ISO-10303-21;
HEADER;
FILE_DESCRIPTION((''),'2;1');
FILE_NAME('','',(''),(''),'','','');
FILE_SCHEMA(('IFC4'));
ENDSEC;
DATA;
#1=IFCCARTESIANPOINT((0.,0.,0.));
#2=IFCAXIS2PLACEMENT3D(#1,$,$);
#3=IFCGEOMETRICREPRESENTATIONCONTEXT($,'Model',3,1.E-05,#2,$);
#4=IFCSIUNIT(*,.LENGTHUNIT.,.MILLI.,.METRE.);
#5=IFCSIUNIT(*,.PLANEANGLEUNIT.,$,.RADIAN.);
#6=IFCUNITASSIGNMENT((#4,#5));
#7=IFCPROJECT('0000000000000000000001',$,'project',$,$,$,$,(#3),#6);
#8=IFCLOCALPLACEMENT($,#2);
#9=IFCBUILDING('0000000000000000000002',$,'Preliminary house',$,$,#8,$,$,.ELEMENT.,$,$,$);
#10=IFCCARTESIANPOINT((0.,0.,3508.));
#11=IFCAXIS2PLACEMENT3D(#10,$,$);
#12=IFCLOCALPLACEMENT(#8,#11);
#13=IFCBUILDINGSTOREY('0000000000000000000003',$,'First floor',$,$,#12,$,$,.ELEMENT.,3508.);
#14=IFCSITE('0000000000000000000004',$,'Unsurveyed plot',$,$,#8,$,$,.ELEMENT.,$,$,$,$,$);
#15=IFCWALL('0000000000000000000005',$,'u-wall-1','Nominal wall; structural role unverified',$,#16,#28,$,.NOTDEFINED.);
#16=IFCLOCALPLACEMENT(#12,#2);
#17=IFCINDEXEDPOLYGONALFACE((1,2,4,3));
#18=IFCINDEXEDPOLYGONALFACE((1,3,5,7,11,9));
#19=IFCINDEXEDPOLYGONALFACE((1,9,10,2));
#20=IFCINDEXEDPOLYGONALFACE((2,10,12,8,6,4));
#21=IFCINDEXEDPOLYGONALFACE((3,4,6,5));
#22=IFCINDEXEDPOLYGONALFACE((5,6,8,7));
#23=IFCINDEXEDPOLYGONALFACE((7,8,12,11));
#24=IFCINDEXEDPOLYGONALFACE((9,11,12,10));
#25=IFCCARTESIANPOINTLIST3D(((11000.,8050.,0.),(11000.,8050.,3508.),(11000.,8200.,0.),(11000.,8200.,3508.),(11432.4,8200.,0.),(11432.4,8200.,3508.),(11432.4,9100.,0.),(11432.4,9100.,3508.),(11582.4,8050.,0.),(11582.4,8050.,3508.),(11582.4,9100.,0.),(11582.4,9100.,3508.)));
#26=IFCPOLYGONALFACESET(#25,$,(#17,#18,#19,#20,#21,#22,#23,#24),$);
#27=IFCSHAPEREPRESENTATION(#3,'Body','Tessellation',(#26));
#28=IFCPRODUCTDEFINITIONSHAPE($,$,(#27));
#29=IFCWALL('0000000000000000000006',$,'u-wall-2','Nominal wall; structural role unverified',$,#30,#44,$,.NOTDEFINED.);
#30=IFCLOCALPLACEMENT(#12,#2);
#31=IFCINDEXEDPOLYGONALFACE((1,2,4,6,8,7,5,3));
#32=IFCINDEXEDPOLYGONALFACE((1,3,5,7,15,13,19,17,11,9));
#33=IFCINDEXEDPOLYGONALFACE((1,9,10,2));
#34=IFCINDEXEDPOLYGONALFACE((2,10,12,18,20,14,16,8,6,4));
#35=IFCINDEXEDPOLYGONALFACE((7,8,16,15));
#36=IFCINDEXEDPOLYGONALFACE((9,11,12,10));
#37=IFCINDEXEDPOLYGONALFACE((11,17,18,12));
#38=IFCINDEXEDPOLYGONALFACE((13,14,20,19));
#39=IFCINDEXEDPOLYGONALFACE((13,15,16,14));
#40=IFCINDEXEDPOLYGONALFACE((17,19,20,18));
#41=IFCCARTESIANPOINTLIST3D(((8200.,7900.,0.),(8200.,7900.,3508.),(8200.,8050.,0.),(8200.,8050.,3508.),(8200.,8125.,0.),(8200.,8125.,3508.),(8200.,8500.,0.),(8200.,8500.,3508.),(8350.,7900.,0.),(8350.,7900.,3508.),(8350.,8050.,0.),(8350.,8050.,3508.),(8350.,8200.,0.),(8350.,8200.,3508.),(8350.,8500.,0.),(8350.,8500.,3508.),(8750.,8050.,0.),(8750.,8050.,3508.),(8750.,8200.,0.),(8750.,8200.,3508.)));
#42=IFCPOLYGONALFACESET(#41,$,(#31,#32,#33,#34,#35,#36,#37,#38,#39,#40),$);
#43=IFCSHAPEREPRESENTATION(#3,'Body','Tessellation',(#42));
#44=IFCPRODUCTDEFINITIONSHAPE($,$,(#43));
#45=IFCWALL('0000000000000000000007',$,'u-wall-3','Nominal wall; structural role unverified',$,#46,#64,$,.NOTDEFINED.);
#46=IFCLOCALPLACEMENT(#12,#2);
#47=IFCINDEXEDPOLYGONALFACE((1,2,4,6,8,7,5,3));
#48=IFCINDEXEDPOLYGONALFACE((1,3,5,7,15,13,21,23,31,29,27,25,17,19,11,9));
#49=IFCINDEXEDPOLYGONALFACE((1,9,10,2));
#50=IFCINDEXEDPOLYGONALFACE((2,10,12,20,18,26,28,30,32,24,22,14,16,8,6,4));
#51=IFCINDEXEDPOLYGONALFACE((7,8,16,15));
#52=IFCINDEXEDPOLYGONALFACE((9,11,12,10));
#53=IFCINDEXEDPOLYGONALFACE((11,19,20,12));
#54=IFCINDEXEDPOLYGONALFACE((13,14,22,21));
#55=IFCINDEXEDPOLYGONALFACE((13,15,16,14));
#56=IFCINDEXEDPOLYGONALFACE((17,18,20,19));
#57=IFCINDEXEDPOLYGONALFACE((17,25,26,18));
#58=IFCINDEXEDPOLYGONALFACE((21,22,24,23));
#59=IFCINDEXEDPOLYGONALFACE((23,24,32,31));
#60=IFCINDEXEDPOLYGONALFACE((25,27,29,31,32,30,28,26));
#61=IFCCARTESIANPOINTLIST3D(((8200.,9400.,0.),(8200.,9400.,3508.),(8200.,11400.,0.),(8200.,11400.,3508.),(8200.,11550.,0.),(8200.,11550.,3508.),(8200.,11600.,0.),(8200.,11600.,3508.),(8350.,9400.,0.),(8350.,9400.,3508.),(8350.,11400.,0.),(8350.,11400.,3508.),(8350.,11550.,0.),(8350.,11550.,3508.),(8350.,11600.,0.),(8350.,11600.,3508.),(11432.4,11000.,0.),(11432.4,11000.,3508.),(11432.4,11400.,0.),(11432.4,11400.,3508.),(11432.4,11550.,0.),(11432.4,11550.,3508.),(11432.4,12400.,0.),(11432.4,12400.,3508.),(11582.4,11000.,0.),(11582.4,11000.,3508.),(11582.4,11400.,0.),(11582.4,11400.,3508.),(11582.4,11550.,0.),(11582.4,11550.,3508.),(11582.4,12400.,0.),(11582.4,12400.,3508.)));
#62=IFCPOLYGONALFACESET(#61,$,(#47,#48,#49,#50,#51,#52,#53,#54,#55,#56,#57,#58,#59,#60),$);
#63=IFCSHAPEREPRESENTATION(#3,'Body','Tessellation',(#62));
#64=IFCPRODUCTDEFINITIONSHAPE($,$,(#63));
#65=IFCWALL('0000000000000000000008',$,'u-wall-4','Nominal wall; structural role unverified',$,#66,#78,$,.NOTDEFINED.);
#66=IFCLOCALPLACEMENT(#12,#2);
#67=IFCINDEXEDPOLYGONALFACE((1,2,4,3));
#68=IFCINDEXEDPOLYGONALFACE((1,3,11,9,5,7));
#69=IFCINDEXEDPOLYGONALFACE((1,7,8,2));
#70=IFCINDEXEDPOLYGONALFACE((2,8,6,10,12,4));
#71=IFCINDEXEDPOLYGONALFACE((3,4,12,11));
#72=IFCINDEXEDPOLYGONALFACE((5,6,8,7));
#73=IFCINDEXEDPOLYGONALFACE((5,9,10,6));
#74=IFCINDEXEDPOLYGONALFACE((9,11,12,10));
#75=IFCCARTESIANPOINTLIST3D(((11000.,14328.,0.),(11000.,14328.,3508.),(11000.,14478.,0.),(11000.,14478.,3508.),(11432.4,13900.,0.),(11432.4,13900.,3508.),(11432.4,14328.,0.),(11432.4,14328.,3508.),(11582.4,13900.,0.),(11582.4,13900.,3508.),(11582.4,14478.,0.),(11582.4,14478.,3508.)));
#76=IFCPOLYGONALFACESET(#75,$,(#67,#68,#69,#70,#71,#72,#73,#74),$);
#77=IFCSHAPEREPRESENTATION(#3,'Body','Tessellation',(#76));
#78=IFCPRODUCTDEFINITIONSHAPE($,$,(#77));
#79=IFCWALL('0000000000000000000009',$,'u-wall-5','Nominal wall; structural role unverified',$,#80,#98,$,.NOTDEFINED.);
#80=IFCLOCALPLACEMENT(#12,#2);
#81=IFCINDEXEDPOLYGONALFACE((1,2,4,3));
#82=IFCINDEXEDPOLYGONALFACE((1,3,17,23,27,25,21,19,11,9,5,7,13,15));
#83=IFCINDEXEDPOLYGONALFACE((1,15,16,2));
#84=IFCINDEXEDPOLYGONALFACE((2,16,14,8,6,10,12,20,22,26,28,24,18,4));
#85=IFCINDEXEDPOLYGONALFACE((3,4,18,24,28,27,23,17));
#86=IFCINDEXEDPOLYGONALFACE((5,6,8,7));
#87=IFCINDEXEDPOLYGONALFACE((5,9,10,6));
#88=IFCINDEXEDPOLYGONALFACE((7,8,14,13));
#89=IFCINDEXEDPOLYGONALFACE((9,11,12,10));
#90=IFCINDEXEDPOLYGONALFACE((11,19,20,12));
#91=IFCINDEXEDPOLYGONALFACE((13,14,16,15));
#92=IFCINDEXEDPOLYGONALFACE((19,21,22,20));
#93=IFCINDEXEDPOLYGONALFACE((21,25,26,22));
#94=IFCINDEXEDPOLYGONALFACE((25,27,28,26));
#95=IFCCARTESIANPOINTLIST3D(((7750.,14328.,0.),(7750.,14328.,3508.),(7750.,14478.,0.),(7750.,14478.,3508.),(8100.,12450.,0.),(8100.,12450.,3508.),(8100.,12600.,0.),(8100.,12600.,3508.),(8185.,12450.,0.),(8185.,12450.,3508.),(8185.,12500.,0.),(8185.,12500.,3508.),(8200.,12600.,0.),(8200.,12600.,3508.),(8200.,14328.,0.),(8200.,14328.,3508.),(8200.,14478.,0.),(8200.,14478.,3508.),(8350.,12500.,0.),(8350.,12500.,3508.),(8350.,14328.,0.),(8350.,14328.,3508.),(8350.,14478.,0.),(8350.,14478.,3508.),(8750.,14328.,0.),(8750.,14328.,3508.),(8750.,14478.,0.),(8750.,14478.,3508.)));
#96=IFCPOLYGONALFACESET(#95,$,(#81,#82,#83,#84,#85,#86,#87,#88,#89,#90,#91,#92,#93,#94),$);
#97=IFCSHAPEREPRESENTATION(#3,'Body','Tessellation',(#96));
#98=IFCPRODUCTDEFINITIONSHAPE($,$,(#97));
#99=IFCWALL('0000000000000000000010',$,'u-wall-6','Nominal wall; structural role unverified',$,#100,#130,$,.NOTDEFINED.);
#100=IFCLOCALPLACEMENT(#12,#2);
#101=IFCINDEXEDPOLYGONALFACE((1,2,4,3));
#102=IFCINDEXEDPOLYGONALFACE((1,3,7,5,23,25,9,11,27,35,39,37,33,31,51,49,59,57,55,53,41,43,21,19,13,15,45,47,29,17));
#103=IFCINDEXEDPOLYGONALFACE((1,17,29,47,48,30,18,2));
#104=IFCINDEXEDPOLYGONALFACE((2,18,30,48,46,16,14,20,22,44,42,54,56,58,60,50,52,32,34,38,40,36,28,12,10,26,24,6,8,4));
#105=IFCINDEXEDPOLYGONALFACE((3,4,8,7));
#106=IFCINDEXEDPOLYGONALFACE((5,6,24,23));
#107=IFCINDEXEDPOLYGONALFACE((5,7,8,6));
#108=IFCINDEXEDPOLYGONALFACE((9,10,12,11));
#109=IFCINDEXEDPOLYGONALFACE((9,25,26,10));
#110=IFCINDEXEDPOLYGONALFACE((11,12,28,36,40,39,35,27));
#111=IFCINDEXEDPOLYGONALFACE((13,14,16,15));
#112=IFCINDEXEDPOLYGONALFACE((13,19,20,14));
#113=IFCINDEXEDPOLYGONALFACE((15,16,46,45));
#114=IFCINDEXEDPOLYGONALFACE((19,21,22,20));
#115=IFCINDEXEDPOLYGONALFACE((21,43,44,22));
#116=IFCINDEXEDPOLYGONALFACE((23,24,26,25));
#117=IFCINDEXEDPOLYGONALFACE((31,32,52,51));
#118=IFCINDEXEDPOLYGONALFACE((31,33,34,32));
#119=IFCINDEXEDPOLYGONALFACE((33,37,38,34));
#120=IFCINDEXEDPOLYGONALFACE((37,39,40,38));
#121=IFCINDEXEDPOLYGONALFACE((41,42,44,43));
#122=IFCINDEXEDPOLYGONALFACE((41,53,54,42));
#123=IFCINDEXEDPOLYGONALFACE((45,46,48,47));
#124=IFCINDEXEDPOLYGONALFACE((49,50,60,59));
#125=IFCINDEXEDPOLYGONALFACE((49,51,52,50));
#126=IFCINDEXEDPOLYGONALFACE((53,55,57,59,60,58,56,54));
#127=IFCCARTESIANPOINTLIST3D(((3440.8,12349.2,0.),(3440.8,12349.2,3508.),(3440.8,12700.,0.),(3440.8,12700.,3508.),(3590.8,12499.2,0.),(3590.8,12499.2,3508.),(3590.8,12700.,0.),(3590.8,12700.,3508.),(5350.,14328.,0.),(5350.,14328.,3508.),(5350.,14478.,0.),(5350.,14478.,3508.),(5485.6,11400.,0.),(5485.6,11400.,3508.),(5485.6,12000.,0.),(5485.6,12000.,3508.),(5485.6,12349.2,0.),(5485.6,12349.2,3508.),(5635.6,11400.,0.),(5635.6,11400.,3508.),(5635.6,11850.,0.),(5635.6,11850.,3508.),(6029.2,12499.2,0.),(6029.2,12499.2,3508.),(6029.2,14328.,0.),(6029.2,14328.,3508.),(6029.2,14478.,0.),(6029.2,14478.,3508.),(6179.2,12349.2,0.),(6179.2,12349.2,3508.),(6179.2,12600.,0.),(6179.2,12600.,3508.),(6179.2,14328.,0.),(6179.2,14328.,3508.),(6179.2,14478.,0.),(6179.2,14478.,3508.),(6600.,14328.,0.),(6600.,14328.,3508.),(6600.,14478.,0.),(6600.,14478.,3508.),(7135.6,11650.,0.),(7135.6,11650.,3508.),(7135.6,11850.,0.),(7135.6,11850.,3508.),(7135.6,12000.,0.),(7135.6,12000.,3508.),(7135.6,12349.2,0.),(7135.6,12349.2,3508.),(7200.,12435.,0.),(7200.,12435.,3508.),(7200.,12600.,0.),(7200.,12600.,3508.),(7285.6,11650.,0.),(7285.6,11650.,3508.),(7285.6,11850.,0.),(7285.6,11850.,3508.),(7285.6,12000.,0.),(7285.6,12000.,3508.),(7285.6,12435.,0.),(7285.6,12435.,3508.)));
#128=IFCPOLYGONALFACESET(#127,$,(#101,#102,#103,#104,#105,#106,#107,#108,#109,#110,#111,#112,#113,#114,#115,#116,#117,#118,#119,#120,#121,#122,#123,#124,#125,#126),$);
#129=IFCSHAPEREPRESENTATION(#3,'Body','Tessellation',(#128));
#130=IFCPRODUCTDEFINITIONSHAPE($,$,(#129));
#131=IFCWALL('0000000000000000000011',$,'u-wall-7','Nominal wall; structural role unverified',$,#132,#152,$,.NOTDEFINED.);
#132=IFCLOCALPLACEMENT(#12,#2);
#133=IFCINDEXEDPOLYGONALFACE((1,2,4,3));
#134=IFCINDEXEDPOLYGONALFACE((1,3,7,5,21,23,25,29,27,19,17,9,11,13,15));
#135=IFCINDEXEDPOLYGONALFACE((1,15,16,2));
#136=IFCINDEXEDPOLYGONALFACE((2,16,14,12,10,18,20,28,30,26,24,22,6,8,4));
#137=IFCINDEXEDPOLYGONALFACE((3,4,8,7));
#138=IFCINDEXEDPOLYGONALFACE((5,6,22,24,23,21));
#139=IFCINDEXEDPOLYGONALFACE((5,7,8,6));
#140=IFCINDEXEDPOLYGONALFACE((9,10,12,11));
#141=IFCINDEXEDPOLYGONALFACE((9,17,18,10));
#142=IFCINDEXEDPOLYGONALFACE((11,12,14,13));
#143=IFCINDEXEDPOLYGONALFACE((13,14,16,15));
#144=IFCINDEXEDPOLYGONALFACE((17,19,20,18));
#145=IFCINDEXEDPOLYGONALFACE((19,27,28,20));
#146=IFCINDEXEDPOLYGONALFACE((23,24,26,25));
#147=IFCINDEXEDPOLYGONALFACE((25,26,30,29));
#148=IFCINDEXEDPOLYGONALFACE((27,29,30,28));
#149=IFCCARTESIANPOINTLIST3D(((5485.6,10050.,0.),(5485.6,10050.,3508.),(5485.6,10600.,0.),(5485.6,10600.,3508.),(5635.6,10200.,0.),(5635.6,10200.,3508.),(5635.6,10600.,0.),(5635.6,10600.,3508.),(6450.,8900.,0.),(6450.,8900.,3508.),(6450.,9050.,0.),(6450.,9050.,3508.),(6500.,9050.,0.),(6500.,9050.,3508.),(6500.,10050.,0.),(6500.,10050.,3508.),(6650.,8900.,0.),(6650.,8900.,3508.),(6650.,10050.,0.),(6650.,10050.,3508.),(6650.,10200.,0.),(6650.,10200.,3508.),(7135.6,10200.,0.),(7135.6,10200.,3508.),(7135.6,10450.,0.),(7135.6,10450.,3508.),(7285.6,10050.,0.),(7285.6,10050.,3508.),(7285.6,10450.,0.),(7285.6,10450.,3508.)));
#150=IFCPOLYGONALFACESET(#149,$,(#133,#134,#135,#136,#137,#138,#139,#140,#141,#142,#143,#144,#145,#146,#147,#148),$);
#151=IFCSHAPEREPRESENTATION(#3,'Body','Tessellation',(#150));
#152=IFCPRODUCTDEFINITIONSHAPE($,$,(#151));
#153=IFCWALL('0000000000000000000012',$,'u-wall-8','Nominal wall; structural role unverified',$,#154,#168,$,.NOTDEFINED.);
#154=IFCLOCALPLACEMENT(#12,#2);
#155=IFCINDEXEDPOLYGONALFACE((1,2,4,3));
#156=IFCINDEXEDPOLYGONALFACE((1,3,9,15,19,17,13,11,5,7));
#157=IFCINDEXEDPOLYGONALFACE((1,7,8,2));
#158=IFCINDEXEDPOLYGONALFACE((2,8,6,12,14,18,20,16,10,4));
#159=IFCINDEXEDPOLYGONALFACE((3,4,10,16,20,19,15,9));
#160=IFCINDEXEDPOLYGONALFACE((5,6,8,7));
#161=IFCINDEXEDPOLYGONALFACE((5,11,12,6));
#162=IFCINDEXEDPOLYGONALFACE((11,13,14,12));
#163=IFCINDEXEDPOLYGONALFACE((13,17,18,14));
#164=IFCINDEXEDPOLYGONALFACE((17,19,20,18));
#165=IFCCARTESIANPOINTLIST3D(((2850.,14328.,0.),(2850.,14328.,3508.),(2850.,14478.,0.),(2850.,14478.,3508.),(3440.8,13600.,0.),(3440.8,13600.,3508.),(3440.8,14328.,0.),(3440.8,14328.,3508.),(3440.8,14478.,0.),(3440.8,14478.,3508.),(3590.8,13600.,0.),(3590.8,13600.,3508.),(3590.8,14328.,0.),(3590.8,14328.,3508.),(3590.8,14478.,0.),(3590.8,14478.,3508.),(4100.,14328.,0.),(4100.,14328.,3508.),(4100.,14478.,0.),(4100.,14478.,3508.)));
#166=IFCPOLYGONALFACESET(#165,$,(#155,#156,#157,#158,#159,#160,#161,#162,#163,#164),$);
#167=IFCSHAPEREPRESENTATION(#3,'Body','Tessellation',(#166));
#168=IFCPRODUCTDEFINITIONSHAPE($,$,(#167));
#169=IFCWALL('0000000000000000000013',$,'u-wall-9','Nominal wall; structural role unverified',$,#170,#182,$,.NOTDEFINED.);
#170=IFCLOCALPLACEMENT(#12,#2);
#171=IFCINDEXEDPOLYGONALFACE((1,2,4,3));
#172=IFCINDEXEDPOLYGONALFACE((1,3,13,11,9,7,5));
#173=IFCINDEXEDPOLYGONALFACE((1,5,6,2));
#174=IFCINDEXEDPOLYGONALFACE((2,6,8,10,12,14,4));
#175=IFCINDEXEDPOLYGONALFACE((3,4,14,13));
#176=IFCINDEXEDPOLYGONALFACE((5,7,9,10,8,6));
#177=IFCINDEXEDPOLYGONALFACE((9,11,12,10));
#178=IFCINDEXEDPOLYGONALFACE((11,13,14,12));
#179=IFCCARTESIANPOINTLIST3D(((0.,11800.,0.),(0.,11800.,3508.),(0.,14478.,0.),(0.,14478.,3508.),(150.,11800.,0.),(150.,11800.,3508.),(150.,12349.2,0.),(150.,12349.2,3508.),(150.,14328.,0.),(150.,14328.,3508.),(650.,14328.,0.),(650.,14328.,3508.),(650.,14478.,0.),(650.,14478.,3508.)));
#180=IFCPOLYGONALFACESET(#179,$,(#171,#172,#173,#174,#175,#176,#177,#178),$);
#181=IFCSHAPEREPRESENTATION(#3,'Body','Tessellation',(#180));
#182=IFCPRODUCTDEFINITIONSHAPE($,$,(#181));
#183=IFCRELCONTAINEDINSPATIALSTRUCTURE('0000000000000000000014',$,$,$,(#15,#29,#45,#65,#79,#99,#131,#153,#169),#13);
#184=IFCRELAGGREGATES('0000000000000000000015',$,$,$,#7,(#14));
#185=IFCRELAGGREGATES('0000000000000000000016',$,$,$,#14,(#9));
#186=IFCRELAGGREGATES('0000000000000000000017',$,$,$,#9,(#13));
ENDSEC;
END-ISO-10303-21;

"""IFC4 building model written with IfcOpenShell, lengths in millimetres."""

from ifc_helpers import new_model, si_unit, frame, origin, place, context, project, spatial, polyline, outline, extrude, element, save


model = new_model("IFC4")

# Units and contexts
model_context = context("Model", 3, precision=1e-05, world=origin())
ifc_project = project(units=[si_unit("LENGTHUNIT", "METRE", prefix="MILLI"), si_unit("PLANEANGLEUNIT", "RADIAN")], contexts=[model_context])

# Site, building, storey
placement_1 = place(None, origin())
site = spatial("IfcSite", under=ifc_project, at=placement_1, Name="Unsurveyed plot", CompositionType="ELEMENT")
building = spatial("IfcBuilding", under=site, at=placement_1, Name="Preliminary house", CompositionType="ELEMENT")
placement_2 = place(placement_1, frame((0.0, 0.0, 3508.0)))
storey = spatial("IfcBuildingStorey", under=building, at=placement_2, Name="First floor", CompositionType="ELEMENT", Elevation=3508.0)

# Walls
element("IfcWall", 1, at=placement_2, inside=storey, Name="u-wall-1", Description="Nominal wall; structural role unverified", PredefinedType="NOTDEFINED", context=model_context, shape_type="SweptSolid", body=[
    extrude(outline(polyline([(11432.4, 9100.0), (11582.4, 9100.0), (11582.4, 8050.0), (11000.0, 8050.0), (11000.0, 8200.0), (11432.4, 8200.0), (11432.4, 9100.0)])), origin(), (0.0, 0.0, 1.0), 3508.0),
])
element("IfcWall", 2, at=placement_2, inside=storey, Name="u-wall-2", Description="Nominal wall; structural role unverified", PredefinedType="NOTDEFINED", context=model_context, shape_type="SweptSolid", body=[
    extrude(outline(polyline([(8350.0, 8500.0), (8350.0, 8200.0), (8750.0, 8200.0), (8750.0, 8050.0), (8350.0, 8050.0), (8350.0, 7900.0), (8200.0, 7900.0), (8200.0, 8050.0), (8200.0, 8125.0), (8200.0, 8500.0), (8350.0, 8500.0)])), origin(), (0.0, 0.0, 1.0), 3508.0),
])
element("IfcWall", 3, at=placement_2, inside=storey, Name="u-wall-3", Description="Nominal wall; structural role unverified", PredefinedType="NOTDEFINED", context=model_context, shape_type="SweptSolid", body=[
    extrude(outline(polyline([(8350.0, 11600.0), (8350.0, 11550.0), (11432.4, 11550.0), (11432.4, 12400.0), (11582.4, 12400.0), (11582.4, 11550.0), (11582.4, 11400.0), (11582.4, 11000.0), (11432.4, 11000.0), (11432.4, 11400.0), (8350.0, 11400.0), (8350.0, 9400.0), (8200.0, 9400.0), (8200.0, 11400.0), (8200.0, 11550.0), (8200.0, 11600.0), (8350.0, 11600.0)])), origin(), (0.0, 0.0, 1.0), 3508.0),
])
element("IfcWall", 4, at=placement_2, inside=storey, Name="u-wall-4", Description="Nominal wall; structural role unverified", PredefinedType="NOTDEFINED", context=model_context, shape_type="SweptSolid", body=[
    extrude(outline(polyline([(11000.0, 14478.0), (11582.4, 14478.0), (11582.4, 13900.0), (11432.4, 13900.0), (11432.4, 14328.0), (11000.0, 14328.0), (11000.0, 14478.0)])), origin(), (0.0, 0.0, 1.0), 3508.0),
])
element("IfcWall", 5, at=placement_2, inside=storey, Name="u-wall-5", Description="Nominal wall; structural role unverified", PredefinedType="NOTDEFINED", context=model_context, shape_type="SweptSolid", body=[
    extrude(outline(polyline([(7750.0, 14478.0), (8200.0, 14478.0), (8350.0, 14478.0), (8750.0, 14478.0), (8750.0, 14328.0), (8350.0, 14328.0), (8350.0, 12500.0), (8185.0, 12500.0), (8185.0, 12450.0), (8100.0, 12450.0), (8100.0, 12600.0), (8200.0, 12600.0), (8200.0, 14328.0), (7750.0, 14328.0), (7750.0, 14478.0)])), origin(), (0.0, 0.0, 1.0), 3508.0),
])
element("IfcWall", 6, at=placement_2, inside=storey, Name="u-wall-6", Description="Nominal wall; structural role unverified", PredefinedType="NOTDEFINED", context=model_context, shape_type="SweptSolid", body=[
    extrude(outline(polyline([(7285.6, 12000.0), (7285.6, 11850.0), (7285.6, 11650.0), (7135.6, 11650.0), (7135.6, 11850.0), (5635.6, 11850.0), (5635.6, 11400.0), (5485.6, 11400.0), (5485.6, 12000.0), (7135.6, 12000.0), (7135.6, 12349.2), (6179.2, 12349.2), (5485.6, 12349.2), (3440.8, 12349.2), (3440.8, 12700.0), (3590.8, 12700.0), (3590.8, 12499.2), (6029.2, 12499.2), (6029.2, 14328.0), (5350.0, 14328.0), (5350.0, 14478.0), (6029.2, 14478.0), (6179.2, 14478.0), (6600.0, 14478.0), (6600.0, 14328.0), (6179.2, 14328.0), (6179.2, 12600.0), (7200.0, 12600.0), (7200.0, 12435.0), (7285.6, 12435.0), (7285.6, 12000.0)])), origin(), (0.0, 0.0, 1.0), 3508.0),
])
element("IfcWall", 7, at=placement_2, inside=storey, Name="u-wall-7", Description="Nominal wall; structural role unverified", PredefinedType="NOTDEFINED", context=model_context, shape_type="SweptSolid", body=[
    extrude(outline(polyline([(7135.6, 10200.0), (7135.6, 10450.0), (7285.6, 10450.0), (7285.6, 10050.0), (6650.0, 10050.0), (6650.0, 8900.0), (6450.0, 8900.0), (6450.0, 9050.0), (6500.0, 9050.0), (6500.0, 10050.0), (5485.6, 10050.0), (5485.6, 10600.0), (5635.6, 10600.0), (5635.6, 10200.0), (6650.0, 10200.0), (7135.6, 10200.0)])), origin(), (0.0, 0.0, 1.0), 3508.0),
])
element("IfcWall", 8, at=placement_2, inside=storey, Name="u-wall-8", Description="Nominal wall; structural role unverified", PredefinedType="NOTDEFINED", context=model_context, shape_type="SweptSolid", body=[
    extrude(outline(polyline([(2850.0, 14328.0), (2850.0, 14478.0), (3440.8, 14478.0), (3590.8, 14478.0), (4100.0, 14478.0), (4100.0, 14328.0), (3590.8, 14328.0), (3590.8, 13600.0), (3440.8, 13600.0), (3440.8, 14328.0), (2850.0, 14328.0)])), origin(), (0.0, 0.0, 1.0), 3508.0),
])
element("IfcWall", 9, at=placement_2, inside=storey, Name="u-wall-9", Description="Nominal wall; structural role unverified", PredefinedType="NOTDEFINED", context=model_context, shape_type="SweptSolid", body=[
    extrude(outline(polyline([(0.0, 14478.0), (650.0, 14478.0), (650.0, 14328.0), (150.0, 14328.0), (150.0, 12349.2), (150.0, 11800.0), (0.0, 11800.0), (0.0, 14478.0)])), origin(), (0.0, 0.0, 1.0), 3508.0),
])

save(model, "model.ifc")
